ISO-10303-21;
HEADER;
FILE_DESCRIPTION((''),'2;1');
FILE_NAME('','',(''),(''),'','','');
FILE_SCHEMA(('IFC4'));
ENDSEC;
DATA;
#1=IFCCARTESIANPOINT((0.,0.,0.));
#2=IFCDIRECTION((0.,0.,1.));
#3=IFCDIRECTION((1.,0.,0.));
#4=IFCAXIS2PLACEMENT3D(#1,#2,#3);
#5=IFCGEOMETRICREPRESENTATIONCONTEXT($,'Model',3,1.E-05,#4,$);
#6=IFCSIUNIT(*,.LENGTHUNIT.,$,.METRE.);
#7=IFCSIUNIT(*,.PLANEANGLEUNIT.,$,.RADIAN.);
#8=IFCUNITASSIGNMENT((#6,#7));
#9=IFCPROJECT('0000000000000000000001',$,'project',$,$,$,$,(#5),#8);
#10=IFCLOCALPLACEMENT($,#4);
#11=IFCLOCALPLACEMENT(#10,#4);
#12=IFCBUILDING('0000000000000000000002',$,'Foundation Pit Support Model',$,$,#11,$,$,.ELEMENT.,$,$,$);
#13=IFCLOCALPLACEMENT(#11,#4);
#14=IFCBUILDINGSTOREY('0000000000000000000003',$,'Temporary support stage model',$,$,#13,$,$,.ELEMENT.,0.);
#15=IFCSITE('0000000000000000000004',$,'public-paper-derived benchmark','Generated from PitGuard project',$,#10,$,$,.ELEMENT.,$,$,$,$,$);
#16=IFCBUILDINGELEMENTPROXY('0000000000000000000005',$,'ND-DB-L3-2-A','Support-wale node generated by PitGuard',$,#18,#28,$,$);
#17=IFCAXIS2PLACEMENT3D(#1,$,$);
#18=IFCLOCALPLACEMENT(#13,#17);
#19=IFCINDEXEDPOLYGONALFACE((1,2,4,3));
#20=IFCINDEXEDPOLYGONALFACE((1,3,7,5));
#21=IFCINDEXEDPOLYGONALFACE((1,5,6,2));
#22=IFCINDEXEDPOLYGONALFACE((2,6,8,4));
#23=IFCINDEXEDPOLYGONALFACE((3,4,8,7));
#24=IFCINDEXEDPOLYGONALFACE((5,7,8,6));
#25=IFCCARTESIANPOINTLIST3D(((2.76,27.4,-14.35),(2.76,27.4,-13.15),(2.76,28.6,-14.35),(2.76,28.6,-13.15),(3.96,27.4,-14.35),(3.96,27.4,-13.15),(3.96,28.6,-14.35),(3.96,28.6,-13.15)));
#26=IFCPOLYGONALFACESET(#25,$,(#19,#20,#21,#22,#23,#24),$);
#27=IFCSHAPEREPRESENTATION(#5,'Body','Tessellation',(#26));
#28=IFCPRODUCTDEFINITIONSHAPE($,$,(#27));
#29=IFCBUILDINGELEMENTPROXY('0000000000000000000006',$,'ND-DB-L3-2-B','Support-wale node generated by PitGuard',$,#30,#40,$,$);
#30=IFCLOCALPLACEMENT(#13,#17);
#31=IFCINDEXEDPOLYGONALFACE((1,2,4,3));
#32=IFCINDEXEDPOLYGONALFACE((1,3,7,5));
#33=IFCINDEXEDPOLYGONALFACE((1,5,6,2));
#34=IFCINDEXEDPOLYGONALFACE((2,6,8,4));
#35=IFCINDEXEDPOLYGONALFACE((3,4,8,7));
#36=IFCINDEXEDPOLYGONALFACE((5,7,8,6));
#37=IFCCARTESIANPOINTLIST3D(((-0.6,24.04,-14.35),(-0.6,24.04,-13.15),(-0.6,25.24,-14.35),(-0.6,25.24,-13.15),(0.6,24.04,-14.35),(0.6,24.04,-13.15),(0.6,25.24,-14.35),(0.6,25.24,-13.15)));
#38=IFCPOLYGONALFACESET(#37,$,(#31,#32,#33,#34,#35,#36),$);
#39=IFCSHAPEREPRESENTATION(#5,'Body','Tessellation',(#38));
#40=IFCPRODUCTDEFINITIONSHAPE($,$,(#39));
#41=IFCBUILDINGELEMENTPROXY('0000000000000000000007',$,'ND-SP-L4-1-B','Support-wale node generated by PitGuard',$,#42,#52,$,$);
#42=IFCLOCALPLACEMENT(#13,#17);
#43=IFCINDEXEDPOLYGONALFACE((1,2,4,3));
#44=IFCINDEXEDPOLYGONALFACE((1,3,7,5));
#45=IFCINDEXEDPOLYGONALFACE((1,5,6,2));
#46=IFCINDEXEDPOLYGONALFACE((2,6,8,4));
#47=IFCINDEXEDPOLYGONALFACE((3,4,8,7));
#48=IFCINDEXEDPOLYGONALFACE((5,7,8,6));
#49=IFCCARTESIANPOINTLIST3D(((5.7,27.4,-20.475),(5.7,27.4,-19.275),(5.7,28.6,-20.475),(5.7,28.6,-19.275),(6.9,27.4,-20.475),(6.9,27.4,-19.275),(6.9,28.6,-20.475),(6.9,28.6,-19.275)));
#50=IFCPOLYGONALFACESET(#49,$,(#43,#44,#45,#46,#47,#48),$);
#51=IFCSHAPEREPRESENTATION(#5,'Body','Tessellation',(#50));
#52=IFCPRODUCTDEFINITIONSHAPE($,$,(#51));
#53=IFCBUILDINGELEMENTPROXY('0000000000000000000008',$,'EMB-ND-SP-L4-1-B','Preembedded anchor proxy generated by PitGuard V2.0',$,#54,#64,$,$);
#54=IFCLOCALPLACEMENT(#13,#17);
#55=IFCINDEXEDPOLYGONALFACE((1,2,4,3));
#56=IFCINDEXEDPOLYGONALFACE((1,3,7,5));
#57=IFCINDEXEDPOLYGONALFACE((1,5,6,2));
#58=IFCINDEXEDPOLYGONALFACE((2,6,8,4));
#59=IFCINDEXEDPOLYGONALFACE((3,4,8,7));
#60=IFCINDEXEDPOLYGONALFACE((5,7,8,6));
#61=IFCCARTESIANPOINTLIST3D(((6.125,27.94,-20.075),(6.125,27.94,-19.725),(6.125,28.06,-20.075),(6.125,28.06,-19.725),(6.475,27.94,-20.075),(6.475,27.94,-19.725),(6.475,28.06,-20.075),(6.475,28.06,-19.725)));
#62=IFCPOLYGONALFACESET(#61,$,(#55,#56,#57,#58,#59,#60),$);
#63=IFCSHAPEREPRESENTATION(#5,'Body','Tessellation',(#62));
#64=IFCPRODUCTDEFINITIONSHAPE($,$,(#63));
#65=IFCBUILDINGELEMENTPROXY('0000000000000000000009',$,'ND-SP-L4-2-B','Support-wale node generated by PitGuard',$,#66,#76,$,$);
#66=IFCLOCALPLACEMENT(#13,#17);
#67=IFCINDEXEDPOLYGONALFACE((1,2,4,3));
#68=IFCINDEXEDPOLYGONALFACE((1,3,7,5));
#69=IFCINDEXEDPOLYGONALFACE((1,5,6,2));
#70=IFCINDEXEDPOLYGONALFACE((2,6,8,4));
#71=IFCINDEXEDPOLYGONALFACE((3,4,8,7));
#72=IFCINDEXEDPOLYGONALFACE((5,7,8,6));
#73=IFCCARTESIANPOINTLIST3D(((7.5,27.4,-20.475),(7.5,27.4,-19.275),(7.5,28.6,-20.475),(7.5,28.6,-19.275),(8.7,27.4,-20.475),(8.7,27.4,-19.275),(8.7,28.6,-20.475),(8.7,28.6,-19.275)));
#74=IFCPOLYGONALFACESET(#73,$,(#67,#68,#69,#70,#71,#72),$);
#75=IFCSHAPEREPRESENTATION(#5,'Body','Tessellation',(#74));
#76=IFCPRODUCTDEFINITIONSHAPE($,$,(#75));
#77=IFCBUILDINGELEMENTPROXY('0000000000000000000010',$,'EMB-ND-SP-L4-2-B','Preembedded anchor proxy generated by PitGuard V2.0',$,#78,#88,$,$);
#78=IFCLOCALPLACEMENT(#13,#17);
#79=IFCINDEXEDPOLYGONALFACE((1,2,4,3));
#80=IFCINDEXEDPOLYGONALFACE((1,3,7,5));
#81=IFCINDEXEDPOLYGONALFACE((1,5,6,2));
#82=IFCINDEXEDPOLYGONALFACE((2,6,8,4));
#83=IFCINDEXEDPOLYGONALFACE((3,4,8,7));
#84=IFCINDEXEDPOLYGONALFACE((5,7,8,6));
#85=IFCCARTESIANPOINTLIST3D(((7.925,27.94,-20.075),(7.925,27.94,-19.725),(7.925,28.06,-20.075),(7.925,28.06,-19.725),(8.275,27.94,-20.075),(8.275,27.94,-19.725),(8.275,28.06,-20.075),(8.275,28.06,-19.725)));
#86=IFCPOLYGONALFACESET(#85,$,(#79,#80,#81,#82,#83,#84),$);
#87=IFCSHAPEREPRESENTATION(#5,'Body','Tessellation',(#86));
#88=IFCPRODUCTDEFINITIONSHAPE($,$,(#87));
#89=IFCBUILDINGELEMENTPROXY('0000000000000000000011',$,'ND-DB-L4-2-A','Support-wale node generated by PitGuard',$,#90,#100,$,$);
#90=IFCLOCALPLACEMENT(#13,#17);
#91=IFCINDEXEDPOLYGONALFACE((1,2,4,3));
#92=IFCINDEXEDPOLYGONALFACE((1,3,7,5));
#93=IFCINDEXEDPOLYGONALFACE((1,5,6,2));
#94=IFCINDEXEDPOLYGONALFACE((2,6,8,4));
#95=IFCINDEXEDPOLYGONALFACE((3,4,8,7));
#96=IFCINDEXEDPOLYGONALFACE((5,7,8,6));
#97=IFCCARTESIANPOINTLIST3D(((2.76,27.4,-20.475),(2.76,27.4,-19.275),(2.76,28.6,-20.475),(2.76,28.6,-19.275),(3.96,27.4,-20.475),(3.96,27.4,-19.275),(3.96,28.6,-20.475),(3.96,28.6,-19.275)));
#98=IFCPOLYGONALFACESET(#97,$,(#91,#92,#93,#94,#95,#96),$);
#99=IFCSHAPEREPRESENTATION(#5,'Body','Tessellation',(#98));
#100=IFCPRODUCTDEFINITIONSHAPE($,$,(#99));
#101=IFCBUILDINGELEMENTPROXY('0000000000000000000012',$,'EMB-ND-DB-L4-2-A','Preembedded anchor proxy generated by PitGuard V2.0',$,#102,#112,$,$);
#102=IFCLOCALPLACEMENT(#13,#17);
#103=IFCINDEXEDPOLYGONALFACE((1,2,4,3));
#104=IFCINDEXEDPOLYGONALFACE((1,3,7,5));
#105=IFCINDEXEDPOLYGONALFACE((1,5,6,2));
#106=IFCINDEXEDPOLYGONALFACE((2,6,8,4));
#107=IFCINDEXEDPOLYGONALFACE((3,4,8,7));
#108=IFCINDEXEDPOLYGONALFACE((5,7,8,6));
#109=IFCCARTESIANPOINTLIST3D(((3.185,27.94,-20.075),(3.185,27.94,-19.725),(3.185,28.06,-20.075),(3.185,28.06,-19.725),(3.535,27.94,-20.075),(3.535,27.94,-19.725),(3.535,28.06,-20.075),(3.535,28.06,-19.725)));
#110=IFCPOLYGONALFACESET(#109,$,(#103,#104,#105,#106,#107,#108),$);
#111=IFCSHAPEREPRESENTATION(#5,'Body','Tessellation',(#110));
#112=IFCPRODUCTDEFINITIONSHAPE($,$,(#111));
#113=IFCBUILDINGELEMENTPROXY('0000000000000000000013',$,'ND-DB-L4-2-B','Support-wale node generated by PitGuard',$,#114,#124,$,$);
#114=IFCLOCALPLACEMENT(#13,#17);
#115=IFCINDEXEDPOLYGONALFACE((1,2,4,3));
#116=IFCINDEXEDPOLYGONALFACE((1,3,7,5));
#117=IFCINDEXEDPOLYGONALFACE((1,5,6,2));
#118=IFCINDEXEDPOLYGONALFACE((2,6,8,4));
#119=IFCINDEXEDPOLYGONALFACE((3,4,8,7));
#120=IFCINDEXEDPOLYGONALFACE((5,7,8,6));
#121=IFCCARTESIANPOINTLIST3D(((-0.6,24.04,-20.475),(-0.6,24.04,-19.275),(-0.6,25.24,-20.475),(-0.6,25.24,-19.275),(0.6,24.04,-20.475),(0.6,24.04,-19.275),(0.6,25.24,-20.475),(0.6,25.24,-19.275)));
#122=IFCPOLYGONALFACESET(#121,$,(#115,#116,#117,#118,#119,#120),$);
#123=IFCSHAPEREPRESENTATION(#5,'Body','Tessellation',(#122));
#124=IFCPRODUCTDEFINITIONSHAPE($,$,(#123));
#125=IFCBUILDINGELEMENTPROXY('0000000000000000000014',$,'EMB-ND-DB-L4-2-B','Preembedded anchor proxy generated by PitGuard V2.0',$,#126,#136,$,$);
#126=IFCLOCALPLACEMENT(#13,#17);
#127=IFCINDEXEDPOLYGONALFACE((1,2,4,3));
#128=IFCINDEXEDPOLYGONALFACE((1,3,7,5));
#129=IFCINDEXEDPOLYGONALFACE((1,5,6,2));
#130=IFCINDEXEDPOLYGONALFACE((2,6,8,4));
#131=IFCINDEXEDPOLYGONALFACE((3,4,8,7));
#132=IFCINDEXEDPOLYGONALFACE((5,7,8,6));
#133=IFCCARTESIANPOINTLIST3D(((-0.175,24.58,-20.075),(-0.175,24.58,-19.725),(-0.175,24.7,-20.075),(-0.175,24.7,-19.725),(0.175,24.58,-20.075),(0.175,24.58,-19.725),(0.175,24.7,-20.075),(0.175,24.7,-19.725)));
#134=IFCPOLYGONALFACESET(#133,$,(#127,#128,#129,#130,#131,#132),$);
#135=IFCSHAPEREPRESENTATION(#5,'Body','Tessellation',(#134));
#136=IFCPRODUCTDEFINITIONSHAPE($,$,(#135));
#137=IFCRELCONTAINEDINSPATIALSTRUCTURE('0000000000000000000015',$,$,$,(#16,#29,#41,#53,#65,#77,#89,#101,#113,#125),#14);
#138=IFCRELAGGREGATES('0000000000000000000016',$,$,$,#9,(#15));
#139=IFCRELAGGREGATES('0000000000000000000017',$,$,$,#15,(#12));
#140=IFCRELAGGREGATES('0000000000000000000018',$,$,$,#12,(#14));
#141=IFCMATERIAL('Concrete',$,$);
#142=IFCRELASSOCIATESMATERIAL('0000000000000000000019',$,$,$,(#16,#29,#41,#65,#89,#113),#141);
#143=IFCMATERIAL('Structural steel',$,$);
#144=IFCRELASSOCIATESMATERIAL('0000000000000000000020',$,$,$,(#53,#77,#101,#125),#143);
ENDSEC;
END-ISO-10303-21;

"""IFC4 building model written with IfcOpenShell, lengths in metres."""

from ifc_helpers import new_model, si_unit, frame, origin_with_axes, origin_2d, place, context, project, spatial, rectangle, extrude, material, element, save


model = new_model("IFC4")

# Units and contexts
model_context = context("Model", 3, precision=1e-05, world=origin_with_axes())
ifc_project = project(units=[si_unit("LENGTHUNIT", "METRE"), si_unit("PLANEANGLEUNIT", "RADIAN")], contexts=[model_context])

# Site, building, storey
site_placement = place(None, origin_with_axes())
site = spatial("IfcSite", under=ifc_project, at=site_placement, Name="public-paper-derived benchmark", Description="Generated from PitGuard project", CompositionType="ELEMENT")
building_placement = place(site_placement, origin_with_axes())
building = spatial("IfcBuilding", under=site, at=building_placement, Name="Foundation Pit Support Model", CompositionType="ELEMENT")
storey_placement = place(building_placement, origin_with_axes())
storey = spatial("IfcBuildingStorey", under=building, at=storey_placement, Name="Temporary support stage model", CompositionType="ELEMENT", Elevation=0.0)

# Shared definitions
ifc_material_1 = material(Name="Concrete")

# Shared definitions
ifc_material_2 = material(Name="Structural steel")

# Building element proxies
for number, where, z_axis, x_axis, name in (
    (1, (3.36, 28.0, -14.35), (0.0, 0.0, 1.0), (1.0, 0.0, 0.0), "ND-DB-L3-2-A"),
    (2, (0.0, 24.64, -14.35), (0.0, 0.0, 1.0), (1.0, 0.0, 0.0), "ND-DB-L3-2-B"),
    (3, (6.3, 28.0, -20.475), (0.0, 0.0, 1.0), (1.0, 0.0, 0.0), "ND-SP-L4-1-B"),
):
    element("IfcBuildingElementProxy", number, at=place(storey_placement, frame(where, z_axis=z_axis, x_axis=x_axis)), inside=storey, material=ifc_material_1, Name=name, Description="Support-wale node generated by PitGuard", context=model_context, shape_type="SweptSolid", body=[
        extrude(rectangle(XDim=1.2, YDim=1.2, at=origin_2d()), origin_with_axes(), (0.0, 0.0, 1.0), 1.2),
    ])
proxy_1_placement = place(storey_placement, frame((6.3, 28.0, -20.075), z_axis=(0.0, 0.0, 1.0), x_axis=(1.0, 0.0, 0.0)))
element("IfcBuildingElementProxy", 4, at=proxy_1_placement, inside=storey, material=ifc_material_2, Name="EMB-ND-SP-L4-1-B", Description="Preembedded anchor proxy generated by PitGuard V2.0", context=model_context, shape_type="SweptSolid", body=[
    extrude(rectangle(XDim=0.35, YDim=0.12, at=origin_2d()), origin_with_axes(), (0.0, 0.0, 1.0), 0.35),
])
proxy_2_placement = place(storey_placement, frame((8.1, 28.0, -20.475), z_axis=(0.0, 0.0, 1.0), x_axis=(1.0, 0.0, 0.0)))
element("IfcBuildingElementProxy", 5, at=proxy_2_placement, inside=storey, material=ifc_material_1, Name="ND-SP-L4-2-B", Description="Support-wale node generated by PitGuard", context=model_context, shape_type="SweptSolid", body=[
    extrude(rectangle(XDim=1.2, YDim=1.2, at=origin_2d()), origin_with_axes(), (0.0, 0.0, 1.0), 1.2),
])
proxy_3_placement = place(storey_placement, frame((8.1, 28.0, -20.075), z_axis=(0.0, 0.0, 1.0), x_axis=(1.0, 0.0, 0.0)))
element("IfcBuildingElementProxy", 6, at=proxy_3_placement, inside=storey, material=ifc_material_2, Name="EMB-ND-SP-L4-2-B", Description="Preembedded anchor proxy generated by PitGuard V2.0", context=model_context, shape_type="SweptSolid", body=[
    extrude(rectangle(XDim=0.35, YDim=0.12, at=origin_2d()), origin_with_axes(), (0.0, 0.0, 1.0), 0.35),
])
proxy_4_placement = place(storey_placement, frame((3.36, 28.0, -20.475), z_axis=(0.0, 0.0, 1.0), x_axis=(1.0, 0.0, 0.0)))
element("IfcBuildingElementProxy", 7, at=proxy_4_placement, inside=storey, material=ifc_material_1, Name="ND-DB-L4-2-A", Description="Support-wale node generated by PitGuard", context=model_context, shape_type="SweptSolid", body=[
    extrude(rectangle(XDim=1.2, YDim=1.2, at=origin_2d()), origin_with_axes(), (0.0, 0.0, 1.0), 1.2),
])
proxy_5_placement = place(storey_placement, frame((3.36, 28.0, -20.075), z_axis=(0.0, 0.0, 1.0), x_axis=(1.0, 0.0, 0.0)))
element("IfcBuildingElementProxy", 8, at=proxy_5_placement, inside=storey, material=ifc_material_2, Name="EMB-ND-DB-L4-2-A", Description="Preembedded anchor proxy generated by PitGuard V2.0", context=model_context, shape_type="SweptSolid", body=[
    extrude(rectangle(XDim=0.35, YDim=0.12, at=origin_2d()), origin_with_axes(), (0.0, 0.0, 1.0), 0.35),
])
proxy_6_placement = place(storey_placement, frame((0.0, 24.64, -20.475), z_axis=(0.0, 0.0, 1.0), x_axis=(1.0, 0.0, 0.0)))
element("IfcBuildingElementProxy", 9, at=proxy_6_placement, inside=storey, material=ifc_material_1, Name="ND-DB-L4-2-B", Description="Support-wale node generated by PitGuard", context=model_context, shape_type="SweptSolid", body=[
    extrude(rectangle(XDim=1.2, YDim=1.2, at=origin_2d()), origin_with_axes(), (0.0, 0.0, 1.0), 1.2),
])
proxy_7_placement = place(storey_placement, frame((0.0, 24.64, -20.075), z_axis=(0.0, 0.0, 1.0), x_axis=(1.0, 0.0, 0.0)))
element("IfcBuildingElementProxy", 10, at=proxy_7_placement, inside=storey, material=ifc_material_2, Name="EMB-ND-DB-L4-2-B", Description="Preembedded anchor proxy generated by PitGuard V2.0", context=model_context, shape_type="SweptSolid", body=[
    extrude(rectangle(XDim=0.35, YDim=0.12, at=origin_2d()), origin_with_axes(), (0.0, 0.0, 1.0), 0.35),
])

save(model, "model.ifc")
